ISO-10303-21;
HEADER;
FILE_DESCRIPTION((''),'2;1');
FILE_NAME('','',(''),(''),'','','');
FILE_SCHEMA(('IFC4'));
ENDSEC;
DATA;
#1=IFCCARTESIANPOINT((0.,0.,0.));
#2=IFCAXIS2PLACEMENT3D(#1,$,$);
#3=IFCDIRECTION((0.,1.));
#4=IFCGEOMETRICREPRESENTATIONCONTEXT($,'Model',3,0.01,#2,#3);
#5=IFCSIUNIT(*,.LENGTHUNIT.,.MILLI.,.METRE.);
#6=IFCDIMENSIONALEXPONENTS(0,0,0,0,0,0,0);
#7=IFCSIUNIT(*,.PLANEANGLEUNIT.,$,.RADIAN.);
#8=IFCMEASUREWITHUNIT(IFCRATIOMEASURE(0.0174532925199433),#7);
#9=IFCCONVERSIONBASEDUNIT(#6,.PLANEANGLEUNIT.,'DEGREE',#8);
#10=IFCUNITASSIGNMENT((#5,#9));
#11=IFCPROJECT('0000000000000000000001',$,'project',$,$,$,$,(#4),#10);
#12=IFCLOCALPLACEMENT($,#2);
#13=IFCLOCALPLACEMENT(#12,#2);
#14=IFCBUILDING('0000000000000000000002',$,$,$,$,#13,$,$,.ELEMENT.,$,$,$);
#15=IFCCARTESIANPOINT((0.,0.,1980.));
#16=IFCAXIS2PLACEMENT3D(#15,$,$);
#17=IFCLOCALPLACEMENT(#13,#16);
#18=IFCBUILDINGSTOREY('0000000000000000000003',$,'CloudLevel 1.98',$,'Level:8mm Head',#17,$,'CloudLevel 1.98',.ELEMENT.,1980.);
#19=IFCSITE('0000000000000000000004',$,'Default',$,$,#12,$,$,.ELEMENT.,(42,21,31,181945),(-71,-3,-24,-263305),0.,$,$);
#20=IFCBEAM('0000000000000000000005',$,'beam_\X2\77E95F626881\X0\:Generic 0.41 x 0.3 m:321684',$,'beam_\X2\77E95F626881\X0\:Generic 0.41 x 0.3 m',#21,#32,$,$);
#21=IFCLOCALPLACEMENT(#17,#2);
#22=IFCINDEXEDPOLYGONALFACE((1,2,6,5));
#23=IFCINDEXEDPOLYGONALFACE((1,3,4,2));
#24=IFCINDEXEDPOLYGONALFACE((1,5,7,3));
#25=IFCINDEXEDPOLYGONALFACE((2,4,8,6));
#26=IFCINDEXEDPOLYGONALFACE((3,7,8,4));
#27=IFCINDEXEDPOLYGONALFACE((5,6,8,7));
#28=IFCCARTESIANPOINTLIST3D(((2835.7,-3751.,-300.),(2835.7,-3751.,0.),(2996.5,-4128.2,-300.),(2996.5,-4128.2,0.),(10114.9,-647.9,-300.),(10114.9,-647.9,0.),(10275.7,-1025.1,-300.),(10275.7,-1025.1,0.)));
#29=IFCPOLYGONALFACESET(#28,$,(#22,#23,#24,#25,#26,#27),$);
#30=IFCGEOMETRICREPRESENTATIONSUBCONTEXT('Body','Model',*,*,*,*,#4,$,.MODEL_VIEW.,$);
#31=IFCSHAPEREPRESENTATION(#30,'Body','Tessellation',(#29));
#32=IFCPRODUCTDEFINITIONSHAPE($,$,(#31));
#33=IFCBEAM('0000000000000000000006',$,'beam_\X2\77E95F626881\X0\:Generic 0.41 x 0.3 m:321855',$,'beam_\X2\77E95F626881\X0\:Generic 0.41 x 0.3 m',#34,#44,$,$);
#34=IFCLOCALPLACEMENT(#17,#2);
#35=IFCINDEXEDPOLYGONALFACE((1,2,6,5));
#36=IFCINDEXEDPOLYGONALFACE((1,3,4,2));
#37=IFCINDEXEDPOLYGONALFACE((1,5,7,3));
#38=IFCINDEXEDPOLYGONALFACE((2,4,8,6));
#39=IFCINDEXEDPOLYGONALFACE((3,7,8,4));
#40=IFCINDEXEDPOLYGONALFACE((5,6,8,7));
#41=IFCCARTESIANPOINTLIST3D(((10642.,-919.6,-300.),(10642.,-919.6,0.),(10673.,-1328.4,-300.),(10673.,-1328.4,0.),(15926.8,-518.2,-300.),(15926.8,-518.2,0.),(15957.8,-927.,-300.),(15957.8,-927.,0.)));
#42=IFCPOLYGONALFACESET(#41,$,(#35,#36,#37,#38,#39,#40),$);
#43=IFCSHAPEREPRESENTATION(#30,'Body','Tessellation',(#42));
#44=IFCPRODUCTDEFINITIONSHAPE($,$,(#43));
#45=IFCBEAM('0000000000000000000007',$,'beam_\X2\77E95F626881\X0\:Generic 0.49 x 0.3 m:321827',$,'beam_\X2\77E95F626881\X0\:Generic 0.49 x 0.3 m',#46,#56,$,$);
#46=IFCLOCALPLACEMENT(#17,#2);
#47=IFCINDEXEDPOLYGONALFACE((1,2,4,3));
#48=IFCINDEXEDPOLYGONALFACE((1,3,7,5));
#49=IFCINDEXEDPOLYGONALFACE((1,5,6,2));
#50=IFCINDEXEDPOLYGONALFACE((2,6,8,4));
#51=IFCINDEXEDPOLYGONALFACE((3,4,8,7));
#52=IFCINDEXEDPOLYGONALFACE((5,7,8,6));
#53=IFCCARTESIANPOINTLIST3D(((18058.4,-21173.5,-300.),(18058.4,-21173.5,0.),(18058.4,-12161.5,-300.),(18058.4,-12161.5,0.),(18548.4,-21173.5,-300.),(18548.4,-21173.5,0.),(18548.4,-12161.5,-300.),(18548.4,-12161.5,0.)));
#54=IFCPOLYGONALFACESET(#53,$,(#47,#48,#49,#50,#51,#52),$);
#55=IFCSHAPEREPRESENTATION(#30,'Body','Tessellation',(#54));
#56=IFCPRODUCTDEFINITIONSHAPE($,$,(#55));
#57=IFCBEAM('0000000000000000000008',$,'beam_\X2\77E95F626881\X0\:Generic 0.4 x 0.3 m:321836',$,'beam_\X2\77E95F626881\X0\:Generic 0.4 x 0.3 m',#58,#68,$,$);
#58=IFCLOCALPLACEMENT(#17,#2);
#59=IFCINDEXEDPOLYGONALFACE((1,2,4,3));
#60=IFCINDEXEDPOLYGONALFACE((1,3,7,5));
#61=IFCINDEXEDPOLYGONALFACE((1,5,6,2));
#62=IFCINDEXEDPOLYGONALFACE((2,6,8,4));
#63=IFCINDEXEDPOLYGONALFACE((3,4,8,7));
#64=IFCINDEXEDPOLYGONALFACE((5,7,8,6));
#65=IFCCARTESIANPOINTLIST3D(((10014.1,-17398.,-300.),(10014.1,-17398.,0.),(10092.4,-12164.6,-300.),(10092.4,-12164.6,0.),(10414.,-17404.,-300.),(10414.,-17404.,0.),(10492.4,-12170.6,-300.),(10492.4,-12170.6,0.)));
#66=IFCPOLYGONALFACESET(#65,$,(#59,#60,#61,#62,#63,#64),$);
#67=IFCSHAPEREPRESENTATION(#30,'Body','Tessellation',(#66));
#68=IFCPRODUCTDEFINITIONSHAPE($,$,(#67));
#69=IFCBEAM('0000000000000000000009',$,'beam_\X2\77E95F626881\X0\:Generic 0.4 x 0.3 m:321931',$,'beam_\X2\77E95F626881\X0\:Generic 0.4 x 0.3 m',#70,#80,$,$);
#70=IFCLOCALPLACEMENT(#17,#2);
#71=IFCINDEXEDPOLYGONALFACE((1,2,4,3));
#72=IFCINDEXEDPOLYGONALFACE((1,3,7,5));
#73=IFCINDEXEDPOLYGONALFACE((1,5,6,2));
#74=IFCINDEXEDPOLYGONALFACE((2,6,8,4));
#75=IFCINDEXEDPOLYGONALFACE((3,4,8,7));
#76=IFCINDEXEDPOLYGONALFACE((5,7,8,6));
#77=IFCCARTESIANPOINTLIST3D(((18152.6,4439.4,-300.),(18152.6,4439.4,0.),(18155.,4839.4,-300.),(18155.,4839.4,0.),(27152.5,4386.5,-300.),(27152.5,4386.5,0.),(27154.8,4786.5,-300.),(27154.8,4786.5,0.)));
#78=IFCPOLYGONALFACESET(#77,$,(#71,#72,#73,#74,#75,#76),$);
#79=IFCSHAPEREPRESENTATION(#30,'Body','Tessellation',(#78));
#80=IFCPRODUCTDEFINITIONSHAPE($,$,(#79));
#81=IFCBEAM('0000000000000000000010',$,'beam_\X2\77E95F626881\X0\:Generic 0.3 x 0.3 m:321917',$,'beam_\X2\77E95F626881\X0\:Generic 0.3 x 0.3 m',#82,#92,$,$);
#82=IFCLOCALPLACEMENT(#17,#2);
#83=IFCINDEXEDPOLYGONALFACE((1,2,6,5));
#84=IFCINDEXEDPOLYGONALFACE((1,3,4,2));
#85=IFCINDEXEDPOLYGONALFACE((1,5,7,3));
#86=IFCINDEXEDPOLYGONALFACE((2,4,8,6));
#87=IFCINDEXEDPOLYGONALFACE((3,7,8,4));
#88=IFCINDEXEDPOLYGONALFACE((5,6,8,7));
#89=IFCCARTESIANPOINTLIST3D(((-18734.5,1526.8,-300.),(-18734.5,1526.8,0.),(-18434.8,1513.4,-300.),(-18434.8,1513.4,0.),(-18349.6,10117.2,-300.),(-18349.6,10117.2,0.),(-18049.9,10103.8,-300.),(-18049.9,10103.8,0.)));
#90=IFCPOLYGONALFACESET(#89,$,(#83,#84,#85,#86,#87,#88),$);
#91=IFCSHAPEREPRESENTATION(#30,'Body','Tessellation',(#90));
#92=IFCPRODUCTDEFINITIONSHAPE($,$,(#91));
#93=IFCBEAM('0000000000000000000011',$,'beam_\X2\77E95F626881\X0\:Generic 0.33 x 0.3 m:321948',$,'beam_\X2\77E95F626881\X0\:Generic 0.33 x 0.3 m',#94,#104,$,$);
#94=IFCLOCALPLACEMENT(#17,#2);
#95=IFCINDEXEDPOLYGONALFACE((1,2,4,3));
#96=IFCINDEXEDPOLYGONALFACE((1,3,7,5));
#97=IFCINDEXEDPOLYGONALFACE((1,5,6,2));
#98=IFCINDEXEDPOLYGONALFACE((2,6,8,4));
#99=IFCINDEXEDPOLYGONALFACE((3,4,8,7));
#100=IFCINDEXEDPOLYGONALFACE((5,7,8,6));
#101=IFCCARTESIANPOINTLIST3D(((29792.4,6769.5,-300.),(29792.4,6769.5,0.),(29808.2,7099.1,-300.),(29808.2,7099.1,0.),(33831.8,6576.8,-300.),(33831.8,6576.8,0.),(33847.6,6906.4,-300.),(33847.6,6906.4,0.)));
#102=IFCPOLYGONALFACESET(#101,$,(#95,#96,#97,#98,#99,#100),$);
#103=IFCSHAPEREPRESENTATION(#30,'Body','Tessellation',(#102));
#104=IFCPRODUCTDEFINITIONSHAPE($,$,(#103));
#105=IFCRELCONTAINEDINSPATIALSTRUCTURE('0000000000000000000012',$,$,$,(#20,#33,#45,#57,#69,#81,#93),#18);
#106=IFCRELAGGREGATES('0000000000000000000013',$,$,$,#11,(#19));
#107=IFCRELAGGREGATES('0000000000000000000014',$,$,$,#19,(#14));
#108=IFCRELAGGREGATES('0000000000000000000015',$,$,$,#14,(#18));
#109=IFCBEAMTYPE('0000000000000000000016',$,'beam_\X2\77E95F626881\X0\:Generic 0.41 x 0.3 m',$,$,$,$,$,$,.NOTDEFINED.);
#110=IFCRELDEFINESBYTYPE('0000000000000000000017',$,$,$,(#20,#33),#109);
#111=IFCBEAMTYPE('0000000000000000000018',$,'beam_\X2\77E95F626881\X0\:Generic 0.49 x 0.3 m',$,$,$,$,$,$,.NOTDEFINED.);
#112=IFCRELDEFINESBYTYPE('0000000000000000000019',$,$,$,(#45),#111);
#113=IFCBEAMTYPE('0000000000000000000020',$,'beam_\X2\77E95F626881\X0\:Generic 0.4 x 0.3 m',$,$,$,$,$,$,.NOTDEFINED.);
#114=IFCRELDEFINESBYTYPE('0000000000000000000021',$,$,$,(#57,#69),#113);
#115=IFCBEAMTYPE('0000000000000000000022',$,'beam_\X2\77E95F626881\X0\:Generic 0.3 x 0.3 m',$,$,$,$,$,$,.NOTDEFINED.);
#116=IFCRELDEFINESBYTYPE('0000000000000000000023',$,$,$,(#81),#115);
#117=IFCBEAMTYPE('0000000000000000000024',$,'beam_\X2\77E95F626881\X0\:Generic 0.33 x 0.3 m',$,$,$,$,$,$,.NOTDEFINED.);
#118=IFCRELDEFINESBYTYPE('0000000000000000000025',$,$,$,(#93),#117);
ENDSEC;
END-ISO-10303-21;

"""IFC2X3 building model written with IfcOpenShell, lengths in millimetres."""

from ifc_helpers import new_model, entity, si_unit, converted_unit, direction, frame, frame_2d, origin, place, context, subcontext, project, spatial, rectangle, extrude, type_object, element, save


model = new_model("IFC2X3")

# Units and contexts
model_context = context("Model", 3, precision=0.01, world=origin(), true_north=direction((0.0, 1.0)))
body_context = subcontext(model_context, "Body", "Model", "MODEL_VIEW")
ifc_project = project(units=[si_unit("LENGTHUNIT", "METRE", prefix="MILLI"), converted_unit("PLANEANGLEUNIT", "DEGREE", entity("IfcRatioMeasure", 0.0174532925199433), si_unit("PLANEANGLEUNIT", "RADIAN"), dimensions=[0, 0, 0, 0, 0, 0, 0])], contexts=[model_context])

# Site, building, storey
site_placement = place(None, origin())
site = spatial("IfcSite", under=ifc_project, at=site_placement, Name="Default", CompositionType="ELEMENT", RefLatitude=(42, 21, 31, 181945), RefLongitude=(-71, -3, -24, -263305), RefElevation=0.0)
building_placement = place(site_placement, origin())
building = spatial("IfcBuilding", under=site, at=building_placement, CompositionType="ELEMENT")
storey_placement = place(building_placement, frame((0.0, 0.0, 1980.0)))
storey = spatial("IfcBuildingStorey", under=building, at=storey_placement, Name="CloudLevel 1.98", ObjectType="Level:8mm Head", LongName="CloudLevel 1.98", CompositionType="ELEMENT", Elevation=1980.0)

# Beams
beam_type_1 = type_object("IfcBeamType", Name="beam_矩形梁:Generic 0.41 x 0.3 m", PredefinedType="NOTDEFINED")
beam_1_placement = place(storey_placement, frame((2915.9, -3939.7, 0.0), z_axis=(0.0, 0.0, 1.0), x_axis=(0.919903, 0.392145, 0.0)))
element("IfcBeam", 1, at=beam_1_placement, inside=storey, type_object=beam_type_1, Name="beam_矩形梁:Generic 0.41 x 0.3 m:321684", ObjectType="beam_矩形梁:Generic 0.41 x 0.3 m", context=body_context, shape_type="SweptSolid", body=[
    extrude(rectangle(XDim=300.0, YDim=410.0, at=frame_2d((0.0, 0.0), x_axis=(1.0, 0.0))), frame((0.2, 0.0, -150.0), z_axis=(1.0, 0.0, 0.0), x_axis=(0.0, 0.0, -1.0)), (0.0, 0.0, 1.0), 7913.0),
])
beam_2_placement = place(storey_placement, frame((15942.3, -722.6, 0.0), z_axis=(0.0, 0.0, 1.0), x_axis=(-0.997128, -0.075733, 0.0)))
element("IfcBeam", 2, at=beam_2_placement, inside=storey, type_object=beam_type_1, Name="beam_矩形梁:Generic 0.41 x 0.3 m:321855", ObjectType="beam_矩形梁:Generic 0.41 x 0.3 m", context=body_context, shape_type="SweptSolid", body=[
    extrude(rectangle(XDim=300.0, YDim=410.0, at=frame_2d((0.0, 0.0), x_axis=(1.0, 0.0))), frame((0.0, 0.0, -150.0), z_axis=(1.0, 0.0, 0.0), x_axis=(0.0, 0.0, -1.0)), (0.0, 0.0, 1.0), 5300.0),
])
beam_type_2 = type_object("IfcBeamType", Name="beam_矩形梁:Generic 0.49 x 0.3 m", PredefinedType="NOTDEFINED")
beam_3_placement = place(storey_placement, frame((18303.4, -12161.4, 0.0), z_axis=(0.0, 0.0, 1.0), x_axis=(0.0, -1.0, 0.0)))
element("IfcBeam", 3, at=beam_3_placement, inside=storey, type_object=beam_type_2, Name="beam_矩形梁:Generic 0.49 x 0.3 m:321827", ObjectType="beam_矩形梁:Generic 0.49 x 0.3 m", context=body_context, shape_type="SweptSolid", body=[
    extrude(rectangle(XDim=300.0, YDim=490.0, at=frame_2d((0.0, 0.0), x_axis=(1.0, 0.0))), frame((0.1, 0.0, -150.0), z_axis=(1.0, 0.0, 0.0), x_axis=(0.0, 0.0, -1.0)), (0.0, 0.0, 1.0), 9012.0),
])
beam_type_3 = type_object("IfcBeamType", Name="beam_矩形梁:Generic 0.4 x 0.3 m", PredefinedType="NOTDEFINED")
beam_4_placement = place(storey_placement, frame((10214.1, -17401.2, 0.0), z_axis=(0.0, 0.0, 1.0), x_axis=(0.014965, 0.999888, 0.0)))
element("IfcBeam", 4, at=beam_4_placement, inside=storey, type_object=beam_type_3, Name="beam_矩形梁:Generic 0.4 x 0.3 m:321836", ObjectType="beam_矩形梁:Generic 0.4 x 0.3 m", context=body_context, shape_type="SweptSolid", body=[
    extrude(rectangle(XDim=300.0, YDim=400.0, at=frame_2d((0.0, 0.0), x_axis=(1.0, 0.0))), frame((0.2, 0.0, -150.0), z_axis=(1.0, 0.0, 0.0), x_axis=(0.0, 0.0, -1.0)), (0.0, 0.0, 1.0), 5234.0),
])
beam_5_placement = place(storey_placement, frame((18153.8, 4639.4, 0.0), z_axis=(0.0, 0.0, 1.0), x_axis=(0.999983, -0.005882, 0.0)))
element("IfcBeam", 5, at=beam_5_placement, inside=storey, type_object=beam_type_3, Name="beam_矩形梁:Generic 0.4 x 0.3 m:321931", ObjectType="beam_矩形梁:Generic 0.4 x 0.3 m", context=body_context, shape_type="SweptSolid", body=[
    extrude(rectangle(XDim=300.0, YDim=400.0, at=frame_2d((0.0, 0.0), x_axis=(1.0, 0.0))), frame((0.0, 0.0, -150.0), z_axis=(1.0, 0.0, 0.0), x_axis=(0.0, 0.0, -1.0)), (0.0, 0.0, 1.0), 9000.0),
])
beam_type_4 = type_object("IfcBeamType", Name="beam_矩形梁:Generic 0.3 x 0.3 m", PredefinedType="NOTDEFINED")
beam_6_placement = place(storey_placement, frame((-18584.7, 1519.6, 0.0), z_axis=(0.0, 0.0, 1.0), x_axis=(0.044762, 0.998998, 0.0)))
element("IfcBeam", 6, at=beam_6_placement, inside=storey, type_object=beam_type_4, Name="beam_矩形梁:Generic 0.3 x 0.3 m:321917", ObjectType="beam_矩形梁:Generic 0.3 x 0.3 m", context=body_context, shape_type="SweptSolid", body=[
    extrude(rectangle(XDim=300.0, YDim=300.0, at=frame_2d((0.0, 0.0), x_axis=(1.0, 0.0))), frame((0.5, 0.0, -150.0), z_axis=(1.0, 0.0, 0.0), x_axis=(0.0, 0.0, -1.0)), (0.0, 0.0, 1.0), 8599.0),
])
beam_type_5 = type_object("IfcBeamType", Name="beam_矩形梁:Generic 0.33 x 0.3 m", PredefinedType="NOTDEFINED")
beam_7_placement = place(storey_placement, frame((29800.1, 6934.3, 0.0), z_axis=(0.0, 0.0, 1.0), x_axis=(0.998864, -0.047661, 0.0)))
element("IfcBeam", 7, at=beam_7_placement, inside=storey, type_object=beam_type_5, Name="beam_矩形梁:Generic 0.33 x 0.3 m:321948", ObjectType="beam_矩形梁:Generic 0.33 x 0.3 m", context=body_context, shape_type="SweptSolid", body=[
    extrude(rectangle(XDim=300.0, YDim=330.0, at=frame_2d((0.0, 0.0), x_axis=(1.0, 0.0))), frame((0.2, 0.0, -150.0), z_axis=(1.0, 0.0, 0.0), x_axis=(0.0, 0.0, -1.0)), (0.0, 0.0, 1.0), 4044.0),
])

save(model, "model.ifc")
